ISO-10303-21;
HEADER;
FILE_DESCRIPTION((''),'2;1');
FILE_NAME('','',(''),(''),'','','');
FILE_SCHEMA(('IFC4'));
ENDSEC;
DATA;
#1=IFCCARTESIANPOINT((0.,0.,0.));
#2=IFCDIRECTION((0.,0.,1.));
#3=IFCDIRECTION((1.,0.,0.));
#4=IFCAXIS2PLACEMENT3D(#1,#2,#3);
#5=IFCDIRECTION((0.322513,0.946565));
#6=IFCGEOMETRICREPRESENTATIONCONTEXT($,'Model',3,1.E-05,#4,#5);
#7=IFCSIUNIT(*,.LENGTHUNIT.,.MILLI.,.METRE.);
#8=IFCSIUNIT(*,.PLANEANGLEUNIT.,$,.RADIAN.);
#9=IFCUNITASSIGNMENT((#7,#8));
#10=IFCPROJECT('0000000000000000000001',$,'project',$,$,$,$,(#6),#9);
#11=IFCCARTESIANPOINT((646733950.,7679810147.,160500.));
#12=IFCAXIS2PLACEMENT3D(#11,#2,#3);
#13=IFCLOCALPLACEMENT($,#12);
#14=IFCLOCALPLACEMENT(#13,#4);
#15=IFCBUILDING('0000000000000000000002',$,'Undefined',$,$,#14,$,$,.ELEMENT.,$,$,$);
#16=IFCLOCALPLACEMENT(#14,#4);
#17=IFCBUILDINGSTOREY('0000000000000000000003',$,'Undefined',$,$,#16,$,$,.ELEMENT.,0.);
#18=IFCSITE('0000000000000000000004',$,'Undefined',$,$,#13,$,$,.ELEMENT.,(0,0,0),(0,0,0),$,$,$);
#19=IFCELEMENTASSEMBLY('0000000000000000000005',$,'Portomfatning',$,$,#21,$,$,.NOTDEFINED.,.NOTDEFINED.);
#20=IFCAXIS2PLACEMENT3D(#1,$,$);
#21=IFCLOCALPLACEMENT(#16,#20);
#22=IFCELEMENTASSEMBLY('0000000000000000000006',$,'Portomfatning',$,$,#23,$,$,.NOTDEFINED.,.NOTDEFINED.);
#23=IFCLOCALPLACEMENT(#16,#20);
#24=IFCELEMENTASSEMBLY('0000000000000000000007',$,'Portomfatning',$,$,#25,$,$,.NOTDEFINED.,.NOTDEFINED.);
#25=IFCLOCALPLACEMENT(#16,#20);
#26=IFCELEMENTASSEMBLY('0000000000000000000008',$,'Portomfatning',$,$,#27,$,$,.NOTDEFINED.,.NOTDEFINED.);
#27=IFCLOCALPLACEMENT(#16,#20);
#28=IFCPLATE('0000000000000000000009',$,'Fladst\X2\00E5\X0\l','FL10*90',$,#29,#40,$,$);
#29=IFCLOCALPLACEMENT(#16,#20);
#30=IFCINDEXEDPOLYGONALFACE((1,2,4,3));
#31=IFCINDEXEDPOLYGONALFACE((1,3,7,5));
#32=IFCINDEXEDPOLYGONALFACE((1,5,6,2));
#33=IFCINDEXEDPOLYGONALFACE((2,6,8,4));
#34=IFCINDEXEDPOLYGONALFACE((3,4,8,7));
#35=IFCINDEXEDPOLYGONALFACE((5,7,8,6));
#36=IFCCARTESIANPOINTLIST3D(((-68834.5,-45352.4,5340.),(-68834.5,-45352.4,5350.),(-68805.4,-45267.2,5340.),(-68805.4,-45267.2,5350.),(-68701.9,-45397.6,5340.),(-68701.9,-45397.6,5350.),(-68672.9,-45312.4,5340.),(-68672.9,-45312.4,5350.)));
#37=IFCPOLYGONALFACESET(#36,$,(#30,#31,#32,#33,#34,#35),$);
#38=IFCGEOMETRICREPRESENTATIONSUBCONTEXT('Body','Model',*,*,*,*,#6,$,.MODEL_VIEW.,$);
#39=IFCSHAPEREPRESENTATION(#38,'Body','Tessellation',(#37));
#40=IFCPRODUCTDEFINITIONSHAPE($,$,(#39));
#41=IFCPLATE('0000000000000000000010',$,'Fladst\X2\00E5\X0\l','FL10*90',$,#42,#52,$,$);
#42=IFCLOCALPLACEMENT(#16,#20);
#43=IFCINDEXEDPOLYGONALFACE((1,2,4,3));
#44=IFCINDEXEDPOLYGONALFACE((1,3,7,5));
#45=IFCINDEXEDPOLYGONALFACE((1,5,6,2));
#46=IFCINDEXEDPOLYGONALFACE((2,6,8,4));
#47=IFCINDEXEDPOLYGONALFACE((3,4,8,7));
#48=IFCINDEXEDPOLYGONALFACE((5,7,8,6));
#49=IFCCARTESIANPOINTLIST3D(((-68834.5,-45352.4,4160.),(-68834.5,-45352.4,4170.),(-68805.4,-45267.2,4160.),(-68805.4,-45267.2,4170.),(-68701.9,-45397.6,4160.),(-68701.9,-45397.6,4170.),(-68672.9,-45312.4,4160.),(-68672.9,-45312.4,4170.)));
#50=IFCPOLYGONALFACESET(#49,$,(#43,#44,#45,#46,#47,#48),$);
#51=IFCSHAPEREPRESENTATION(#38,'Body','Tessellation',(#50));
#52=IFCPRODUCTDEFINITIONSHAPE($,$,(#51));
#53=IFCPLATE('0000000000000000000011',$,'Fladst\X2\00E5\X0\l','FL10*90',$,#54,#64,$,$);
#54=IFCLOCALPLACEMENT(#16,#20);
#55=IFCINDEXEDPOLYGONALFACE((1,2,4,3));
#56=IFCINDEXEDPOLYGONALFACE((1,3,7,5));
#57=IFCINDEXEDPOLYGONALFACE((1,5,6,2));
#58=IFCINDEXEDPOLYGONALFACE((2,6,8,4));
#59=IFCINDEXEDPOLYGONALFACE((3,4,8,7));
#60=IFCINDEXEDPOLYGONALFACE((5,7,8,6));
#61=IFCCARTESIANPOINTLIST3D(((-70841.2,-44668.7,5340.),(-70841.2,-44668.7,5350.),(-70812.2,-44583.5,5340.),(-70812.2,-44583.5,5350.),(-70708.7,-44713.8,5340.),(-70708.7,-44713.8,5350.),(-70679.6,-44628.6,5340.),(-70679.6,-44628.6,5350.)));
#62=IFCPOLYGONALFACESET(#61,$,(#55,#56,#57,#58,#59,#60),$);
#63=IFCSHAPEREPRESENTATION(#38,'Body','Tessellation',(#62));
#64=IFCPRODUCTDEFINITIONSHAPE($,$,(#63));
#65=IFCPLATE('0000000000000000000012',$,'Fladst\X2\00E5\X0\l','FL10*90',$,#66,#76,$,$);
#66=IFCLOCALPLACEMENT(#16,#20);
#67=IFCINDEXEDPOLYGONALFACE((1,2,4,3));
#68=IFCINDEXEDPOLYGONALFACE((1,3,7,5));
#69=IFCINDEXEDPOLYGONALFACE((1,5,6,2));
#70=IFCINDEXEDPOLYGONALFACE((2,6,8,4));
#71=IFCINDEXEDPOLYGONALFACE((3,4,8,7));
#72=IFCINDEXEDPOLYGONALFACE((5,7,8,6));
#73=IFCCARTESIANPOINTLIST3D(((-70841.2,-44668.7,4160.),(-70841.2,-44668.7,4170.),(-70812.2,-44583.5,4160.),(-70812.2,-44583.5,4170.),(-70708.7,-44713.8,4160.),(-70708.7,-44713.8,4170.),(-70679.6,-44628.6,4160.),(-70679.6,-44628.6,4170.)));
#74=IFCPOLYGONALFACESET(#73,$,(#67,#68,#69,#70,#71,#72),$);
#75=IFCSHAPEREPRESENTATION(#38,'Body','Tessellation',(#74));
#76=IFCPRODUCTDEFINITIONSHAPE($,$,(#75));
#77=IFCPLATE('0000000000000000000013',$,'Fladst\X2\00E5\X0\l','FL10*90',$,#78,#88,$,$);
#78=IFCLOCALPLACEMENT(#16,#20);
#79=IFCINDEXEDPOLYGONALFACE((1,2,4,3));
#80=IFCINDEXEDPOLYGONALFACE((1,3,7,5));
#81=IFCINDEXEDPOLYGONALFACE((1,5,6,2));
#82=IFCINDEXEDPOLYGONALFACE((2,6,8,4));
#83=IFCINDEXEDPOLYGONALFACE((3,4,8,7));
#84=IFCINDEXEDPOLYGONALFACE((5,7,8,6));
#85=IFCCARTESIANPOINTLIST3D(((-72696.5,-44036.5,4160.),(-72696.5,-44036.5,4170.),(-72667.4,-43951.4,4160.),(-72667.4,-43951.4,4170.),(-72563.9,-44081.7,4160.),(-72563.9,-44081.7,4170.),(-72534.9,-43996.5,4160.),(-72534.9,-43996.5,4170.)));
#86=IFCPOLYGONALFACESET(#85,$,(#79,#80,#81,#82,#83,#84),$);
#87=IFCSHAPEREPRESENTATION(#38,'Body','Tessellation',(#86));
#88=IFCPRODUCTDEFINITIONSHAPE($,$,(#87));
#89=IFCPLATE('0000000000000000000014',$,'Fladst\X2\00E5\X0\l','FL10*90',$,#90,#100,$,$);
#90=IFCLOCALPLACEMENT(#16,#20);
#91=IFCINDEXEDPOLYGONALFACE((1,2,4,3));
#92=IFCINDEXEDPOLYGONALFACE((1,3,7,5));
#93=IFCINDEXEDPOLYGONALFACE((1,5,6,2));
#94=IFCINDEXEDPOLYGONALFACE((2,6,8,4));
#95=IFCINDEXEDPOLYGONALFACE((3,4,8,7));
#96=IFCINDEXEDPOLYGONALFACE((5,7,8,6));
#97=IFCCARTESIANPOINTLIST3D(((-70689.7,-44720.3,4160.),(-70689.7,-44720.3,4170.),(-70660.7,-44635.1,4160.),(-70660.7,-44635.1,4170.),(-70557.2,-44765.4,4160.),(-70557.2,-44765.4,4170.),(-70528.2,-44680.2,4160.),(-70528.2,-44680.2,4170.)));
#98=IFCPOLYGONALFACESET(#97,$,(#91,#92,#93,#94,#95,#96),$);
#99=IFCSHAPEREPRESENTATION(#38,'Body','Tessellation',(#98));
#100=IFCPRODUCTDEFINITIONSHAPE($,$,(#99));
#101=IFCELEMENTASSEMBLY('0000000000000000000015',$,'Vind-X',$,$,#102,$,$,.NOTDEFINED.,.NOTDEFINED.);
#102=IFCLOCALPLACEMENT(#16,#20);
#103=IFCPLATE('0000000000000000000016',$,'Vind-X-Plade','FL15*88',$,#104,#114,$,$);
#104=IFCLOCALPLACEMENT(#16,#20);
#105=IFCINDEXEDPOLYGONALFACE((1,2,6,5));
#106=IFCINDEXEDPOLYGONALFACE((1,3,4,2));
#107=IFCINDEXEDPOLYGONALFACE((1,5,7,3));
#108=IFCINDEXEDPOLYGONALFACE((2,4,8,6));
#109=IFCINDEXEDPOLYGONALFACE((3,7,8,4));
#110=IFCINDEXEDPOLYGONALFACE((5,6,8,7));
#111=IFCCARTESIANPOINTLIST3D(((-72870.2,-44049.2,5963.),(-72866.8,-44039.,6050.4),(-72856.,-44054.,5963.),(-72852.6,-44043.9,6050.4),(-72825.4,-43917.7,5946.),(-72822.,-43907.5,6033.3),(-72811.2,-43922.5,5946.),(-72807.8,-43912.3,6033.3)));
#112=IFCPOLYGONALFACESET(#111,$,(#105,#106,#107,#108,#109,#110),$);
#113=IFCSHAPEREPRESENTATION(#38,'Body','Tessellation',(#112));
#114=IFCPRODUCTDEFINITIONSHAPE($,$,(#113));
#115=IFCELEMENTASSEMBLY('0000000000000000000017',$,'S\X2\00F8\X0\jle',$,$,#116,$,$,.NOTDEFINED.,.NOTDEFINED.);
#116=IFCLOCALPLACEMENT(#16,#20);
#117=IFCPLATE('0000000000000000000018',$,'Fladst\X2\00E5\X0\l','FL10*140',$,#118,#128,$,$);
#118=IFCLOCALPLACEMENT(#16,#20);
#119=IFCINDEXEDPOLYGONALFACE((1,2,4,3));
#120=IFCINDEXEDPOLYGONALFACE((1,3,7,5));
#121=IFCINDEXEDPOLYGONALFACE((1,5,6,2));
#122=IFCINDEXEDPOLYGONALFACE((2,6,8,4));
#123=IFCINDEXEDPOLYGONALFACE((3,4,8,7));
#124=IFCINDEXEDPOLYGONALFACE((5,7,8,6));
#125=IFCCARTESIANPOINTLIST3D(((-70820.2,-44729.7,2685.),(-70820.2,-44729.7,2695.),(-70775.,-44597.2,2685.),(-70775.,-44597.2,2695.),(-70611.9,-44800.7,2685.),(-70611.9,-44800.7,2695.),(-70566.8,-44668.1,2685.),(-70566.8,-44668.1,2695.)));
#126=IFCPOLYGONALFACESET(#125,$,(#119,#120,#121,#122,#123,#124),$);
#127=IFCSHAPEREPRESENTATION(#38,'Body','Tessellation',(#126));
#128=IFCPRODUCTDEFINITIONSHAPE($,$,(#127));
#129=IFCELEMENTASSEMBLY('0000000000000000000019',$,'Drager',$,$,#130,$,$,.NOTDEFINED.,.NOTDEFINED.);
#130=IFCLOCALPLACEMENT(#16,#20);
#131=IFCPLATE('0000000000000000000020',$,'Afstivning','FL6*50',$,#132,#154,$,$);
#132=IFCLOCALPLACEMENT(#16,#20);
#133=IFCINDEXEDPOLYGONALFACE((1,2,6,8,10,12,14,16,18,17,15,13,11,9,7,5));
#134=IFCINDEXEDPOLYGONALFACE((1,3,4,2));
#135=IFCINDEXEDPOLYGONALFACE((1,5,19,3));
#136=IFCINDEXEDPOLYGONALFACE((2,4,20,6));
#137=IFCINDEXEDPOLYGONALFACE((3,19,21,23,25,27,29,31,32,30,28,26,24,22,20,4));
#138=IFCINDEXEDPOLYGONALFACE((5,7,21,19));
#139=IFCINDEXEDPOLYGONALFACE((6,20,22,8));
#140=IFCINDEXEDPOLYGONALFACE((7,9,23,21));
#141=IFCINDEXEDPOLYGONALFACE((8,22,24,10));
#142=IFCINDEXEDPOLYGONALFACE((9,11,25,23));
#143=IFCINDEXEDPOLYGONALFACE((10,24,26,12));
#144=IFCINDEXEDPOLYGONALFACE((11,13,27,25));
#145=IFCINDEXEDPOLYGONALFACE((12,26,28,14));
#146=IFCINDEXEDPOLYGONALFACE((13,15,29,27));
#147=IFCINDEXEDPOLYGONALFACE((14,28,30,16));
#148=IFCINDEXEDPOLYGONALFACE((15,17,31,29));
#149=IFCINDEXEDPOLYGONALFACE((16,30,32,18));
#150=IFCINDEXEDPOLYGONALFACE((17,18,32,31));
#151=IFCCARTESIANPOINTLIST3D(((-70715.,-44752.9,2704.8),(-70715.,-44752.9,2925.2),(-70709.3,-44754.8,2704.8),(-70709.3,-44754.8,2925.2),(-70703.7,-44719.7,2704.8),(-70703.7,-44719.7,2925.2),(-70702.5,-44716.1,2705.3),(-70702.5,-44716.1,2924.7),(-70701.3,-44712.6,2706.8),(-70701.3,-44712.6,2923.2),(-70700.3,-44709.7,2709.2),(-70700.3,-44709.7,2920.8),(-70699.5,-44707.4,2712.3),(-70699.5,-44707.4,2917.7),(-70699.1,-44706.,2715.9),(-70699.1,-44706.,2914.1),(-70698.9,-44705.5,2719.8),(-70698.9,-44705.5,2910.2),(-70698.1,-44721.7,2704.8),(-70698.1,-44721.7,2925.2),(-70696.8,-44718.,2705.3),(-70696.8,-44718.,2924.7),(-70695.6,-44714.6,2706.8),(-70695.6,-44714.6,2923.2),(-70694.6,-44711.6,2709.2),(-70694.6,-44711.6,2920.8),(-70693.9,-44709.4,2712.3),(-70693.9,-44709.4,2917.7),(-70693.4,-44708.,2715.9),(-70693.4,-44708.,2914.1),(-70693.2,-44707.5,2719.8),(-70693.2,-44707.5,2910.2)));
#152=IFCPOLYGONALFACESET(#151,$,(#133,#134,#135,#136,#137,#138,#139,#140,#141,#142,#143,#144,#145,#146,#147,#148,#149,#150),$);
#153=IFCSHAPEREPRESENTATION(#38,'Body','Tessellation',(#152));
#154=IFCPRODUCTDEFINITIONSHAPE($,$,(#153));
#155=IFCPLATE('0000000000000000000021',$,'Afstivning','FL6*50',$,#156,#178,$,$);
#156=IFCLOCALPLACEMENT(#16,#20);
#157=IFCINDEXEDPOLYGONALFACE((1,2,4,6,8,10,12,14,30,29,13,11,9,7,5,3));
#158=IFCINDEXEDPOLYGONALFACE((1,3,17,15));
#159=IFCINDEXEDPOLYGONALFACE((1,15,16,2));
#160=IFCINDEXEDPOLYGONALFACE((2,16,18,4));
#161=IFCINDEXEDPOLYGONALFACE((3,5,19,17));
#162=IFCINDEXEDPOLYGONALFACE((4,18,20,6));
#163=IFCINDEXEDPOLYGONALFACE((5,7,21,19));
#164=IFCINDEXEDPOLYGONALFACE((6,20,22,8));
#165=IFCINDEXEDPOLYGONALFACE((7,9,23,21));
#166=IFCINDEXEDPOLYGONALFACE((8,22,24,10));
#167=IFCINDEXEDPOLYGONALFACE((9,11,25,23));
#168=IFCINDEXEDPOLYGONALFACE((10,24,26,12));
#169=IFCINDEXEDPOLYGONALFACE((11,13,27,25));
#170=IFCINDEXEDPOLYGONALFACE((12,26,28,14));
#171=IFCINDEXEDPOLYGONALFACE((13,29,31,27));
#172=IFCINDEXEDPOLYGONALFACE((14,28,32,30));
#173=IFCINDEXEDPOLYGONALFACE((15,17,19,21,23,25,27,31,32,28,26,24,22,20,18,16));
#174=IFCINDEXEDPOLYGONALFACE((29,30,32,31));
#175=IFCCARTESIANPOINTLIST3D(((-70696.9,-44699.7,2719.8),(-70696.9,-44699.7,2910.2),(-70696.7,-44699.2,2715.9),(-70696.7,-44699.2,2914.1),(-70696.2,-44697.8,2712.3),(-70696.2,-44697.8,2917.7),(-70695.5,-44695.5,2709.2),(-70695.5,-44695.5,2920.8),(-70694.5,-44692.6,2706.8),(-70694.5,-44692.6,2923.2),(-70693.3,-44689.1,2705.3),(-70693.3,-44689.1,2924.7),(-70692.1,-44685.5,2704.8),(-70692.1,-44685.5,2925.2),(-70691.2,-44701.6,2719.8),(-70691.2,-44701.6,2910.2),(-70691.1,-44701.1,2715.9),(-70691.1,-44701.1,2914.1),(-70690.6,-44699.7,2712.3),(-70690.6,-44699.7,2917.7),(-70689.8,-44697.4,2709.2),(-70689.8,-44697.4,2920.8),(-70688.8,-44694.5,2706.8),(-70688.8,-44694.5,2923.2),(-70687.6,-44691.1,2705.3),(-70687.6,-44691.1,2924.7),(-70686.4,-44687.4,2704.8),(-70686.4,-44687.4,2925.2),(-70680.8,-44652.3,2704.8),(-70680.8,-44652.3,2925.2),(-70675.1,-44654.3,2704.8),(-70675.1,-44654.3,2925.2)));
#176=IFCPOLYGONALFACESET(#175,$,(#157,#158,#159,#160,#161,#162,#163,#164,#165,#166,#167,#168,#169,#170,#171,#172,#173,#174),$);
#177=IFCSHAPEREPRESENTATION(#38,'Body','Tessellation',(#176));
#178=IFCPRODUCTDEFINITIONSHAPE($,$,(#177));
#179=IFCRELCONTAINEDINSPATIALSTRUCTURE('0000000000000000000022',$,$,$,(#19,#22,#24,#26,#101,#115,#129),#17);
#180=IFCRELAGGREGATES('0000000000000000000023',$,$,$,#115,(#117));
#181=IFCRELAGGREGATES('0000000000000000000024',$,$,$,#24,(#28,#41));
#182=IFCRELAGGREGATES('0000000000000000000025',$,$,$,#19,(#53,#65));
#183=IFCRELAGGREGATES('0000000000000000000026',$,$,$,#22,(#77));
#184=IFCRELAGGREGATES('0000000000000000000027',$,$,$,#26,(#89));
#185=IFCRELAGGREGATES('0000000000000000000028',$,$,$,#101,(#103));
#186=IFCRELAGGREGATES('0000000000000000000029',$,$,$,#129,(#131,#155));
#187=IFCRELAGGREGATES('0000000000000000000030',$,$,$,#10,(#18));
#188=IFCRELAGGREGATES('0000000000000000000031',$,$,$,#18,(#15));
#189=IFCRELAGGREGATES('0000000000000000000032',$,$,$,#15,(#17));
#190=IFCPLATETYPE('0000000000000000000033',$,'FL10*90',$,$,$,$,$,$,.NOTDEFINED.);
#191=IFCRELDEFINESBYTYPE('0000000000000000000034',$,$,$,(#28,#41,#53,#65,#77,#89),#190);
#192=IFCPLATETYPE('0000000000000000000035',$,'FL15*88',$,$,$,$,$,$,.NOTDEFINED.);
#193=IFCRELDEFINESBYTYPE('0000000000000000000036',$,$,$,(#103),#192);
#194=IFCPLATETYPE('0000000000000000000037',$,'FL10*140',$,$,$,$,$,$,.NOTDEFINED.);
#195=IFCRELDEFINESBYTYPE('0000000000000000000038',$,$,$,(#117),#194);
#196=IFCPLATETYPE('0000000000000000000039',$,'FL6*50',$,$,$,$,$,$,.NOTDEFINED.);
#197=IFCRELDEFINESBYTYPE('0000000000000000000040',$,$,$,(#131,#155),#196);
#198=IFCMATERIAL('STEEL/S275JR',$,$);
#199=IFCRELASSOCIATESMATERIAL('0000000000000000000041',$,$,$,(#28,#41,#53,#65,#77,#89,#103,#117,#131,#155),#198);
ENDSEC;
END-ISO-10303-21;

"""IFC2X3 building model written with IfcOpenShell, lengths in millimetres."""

from ifc_helpers import new_model, si_unit, direction, frame, frame_2d, origin_with_axes, place, context, subcontext, project, spatial, polyline, circle_curve, parameter, trimmed, segment, composite_curve, outline, extrude, material, type_object, element, aggregate, save


model = new_model("IFC2X3")

# Units and contexts
model_context = context("Model", 3, precision=1e-05, world=origin_with_axes(), true_north=direction((0.322513, 0.946565)))
body_context = subcontext(model_context, "Body", "Model", "MODEL_VIEW")
ifc_project = project(units=[si_unit("LENGTHUNIT", "METRE", prefix="MILLI"), si_unit("PLANEANGLEUNIT", "RADIAN")], contexts=[model_context])

# Site, building, storey
site_placement = place(None, frame((646733950.0, 7679810147.0, 160500.0), z_axis=(0.0, 0.0, 1.0), x_axis=(1.0, 0.0, 0.0)))
site = spatial("IfcSite", under=ifc_project, at=site_placement, Name="Undefined", CompositionType="ELEMENT", RefLatitude=(0, 0, 0), RefLongitude=(0, 0, 0))
building_placement = place(site_placement, origin_with_axes())
building = spatial("IfcBuilding", under=site, at=building_placement, Name="Undefined", CompositionType="ELEMENT")
storey_placement = place(building_placement, origin_with_axes())
storey = spatial("IfcBuildingStorey", under=building, at=storey_placement, Name="Undefined", CompositionType="ELEMENT", Elevation=0.0)

# Element assemblies
assembly_1_placement = place(storey_placement, origin_with_axes())
assembly_1 = element("IfcElementAssembly", 1, at=assembly_1_placement, inside=storey, Name="Portomfatning", AssemblyPlace="NOTDEFINED", PredefinedType="NOTDEFINED")
assembly_2_placement = place(storey_placement, origin_with_axes())
assembly_2 = element("IfcElementAssembly", 2, at=assembly_2_placement, inside=storey, Name="Portomfatning", AssemblyPlace="NOTDEFINED", PredefinedType="NOTDEFINED")
assembly_3_placement = place(storey_placement, origin_with_axes())
assembly_3 = element("IfcElementAssembly", 3, at=assembly_3_placement, inside=storey, Name="Portomfatning", AssemblyPlace="NOTDEFINED", PredefinedType="NOTDEFINED")
assembly_4_placement = place(storey_placement, origin_with_axes())
assembly_4 = element("IfcElementAssembly", 4, at=assembly_4_placement, inside=storey, Name="Portomfatning", AssemblyPlace="NOTDEFINED", PredefinedType="NOTDEFINED")

# Shared definitions
ifc_material_1 = material(Name="STEEL/S275JR")

# Plates
plate_type_1 = type_object("IfcPlateType", Name="FL10*90", PredefinedType="NOTDEFINED")
plate_1_placement = place(assembly_3_placement, frame((-68820.0, -45309.8, 5345.0), z_axis=(0.0, 0.0, -1.0), x_axis=(0.946565, -0.322513, 0.0)))
plate_1 = element("IfcPlate", 5, at=plate_1_placement, type_object=plate_type_1, material=ifc_material_1, Name="Fladstål", Description="FL10*90", context=body_context, shape_type="SweptSolid", body=[
    extrude(outline(polyline([(0.0, -45.0), (0.0, 45.0), (140.0, 45.0), (140.0, -45.0), (0.0, -45.0)])), frame((0.0, 0.0, -5.0), z_axis=(0.0, 0.0, 1.0), x_axis=(1.0, 0.0, 0.0)), (0.0, 0.0, 1.0), 10.0),
])
plate_2_placement = place(assembly_3_placement, frame((-68820.0, -45309.8, 4165.0), z_axis=(0.0, 0.0, 1.0), x_axis=(0.946565, -0.322513, 0.0)))
plate_2 = element("IfcPlate", 6, at=plate_2_placement, type_object=plate_type_1, material=ifc_material_1, Name="Fladstål", Description="FL10*90", context=body_context, shape_type="SweptSolid", body=[
    extrude(outline(polyline([(0.0, -45.0), (0.0, 45.0), (140.0, 45.0), (140.0, -45.0), (0.0, -45.0)])), frame((0.0, 0.0, -5.0), z_axis=(0.0, 0.0, 1.0), x_axis=(1.0, 0.0, 0.0)), (0.0, 0.0, 1.0), 10.0),
])
plate_3_placement = place(assembly_1_placement, frame((-70826.7, -44626.1, 5345.0), z_axis=(0.0, 0.0, -1.0), x_axis=(0.946565, -0.322513, 0.0)))
plate_3 = element("IfcPlate", 7, at=plate_3_placement, type_object=plate_type_1, material=ifc_material_1, Name="Fladstål", Description="FL10*90", context=body_context, shape_type="SweptSolid", body=[
    extrude(outline(polyline([(0.0, -45.0), (0.0, 45.0), (140.0, 45.0), (140.0, -45.0), (0.0, -45.0)])), frame((0.0, 0.0, -5.0), z_axis=(0.0, 0.0, 1.0), x_axis=(1.0, 0.0, 0.0)), (0.0, 0.0, 1.0), 10.0),
])
plate_4_placement = place(assembly_1_placement, frame((-70826.7, -44626.1, 4165.0), z_axis=(0.0, 0.0, 1.0), x_axis=(0.946565, -0.322513, 0.0)))
plate_4 = element("IfcPlate", 8, at=plate_4_placement, type_object=plate_type_1, material=ifc_material_1, Name="Fladstål", Description="FL10*90", context=body_context, shape_type="SweptSolid", body=[
    extrude(outline(polyline([(0.0, -45.0), (0.0, 45.0), (140.0, 45.0), (140.0, -45.0), (0.0, -45.0)])), frame((0.0, 0.0, -5.0), z_axis=(0.0, 0.0, 1.0), x_axis=(1.0, 0.0, 0.0)), (0.0, 0.0, 1.0), 10.0),
])
plate_5_placement = place(assembly_2_placement, frame((-72549.4, -44039.1, 4165.0), z_axis=(0.0, 0.0, 1.0), x_axis=(-0.946565, 0.322513, 0.0)))
plate_5 = element("IfcPlate", 9, at=plate_5_placement, type_object=plate_type_1, material=ifc_material_1, Name="Fladstål", Description="FL10*90", context=body_context, shape_type="SweptSolid", body=[
    extrude(outline(polyline([(0.0, -45.0), (0.0, 45.0), (140.0, 45.0), (140.0, -45.0), (0.0, -45.0)])), frame((0.0, 0.0, -5.0), z_axis=(0.0, 0.0, 1.0), x_axis=(1.0, 0.0, 0.0)), (0.0, 0.0, 1.0), 10.0),
])
plate_6_placement = place(assembly_4_placement, frame((-70542.7, -44722.8, 4165.0), z_axis=(0.0, 0.0, 1.0), x_axis=(-0.946565, 0.322513, 0.0)))
plate_6 = element("IfcPlate", 10, at=plate_6_placement, type_object=plate_type_1, material=ifc_material_1, Name="Fladstål", Description="FL10*90", context=body_context, shape_type="SweptSolid", body=[
    extrude(outline(polyline([(0.0, -45.0), (0.0, 45.0), (140.0, 45.0), (140.0, -45.0), (0.0, -45.0)])), frame((0.0, 0.0, -5.0), z_axis=(0.0, 0.0, 1.0), x_axis=(1.0, 0.0, 0.0)), (0.0, 0.0, 1.0), 10.0),
])

# Element assemblies, plates
assembly_5_placement = place(storey_placement, origin_with_axes())
assembly_5 = element("IfcElementAssembly", 11, at=assembly_5_placement, inside=storey, Name="Vind-X", AssemblyPlace="NOTDEFINED", PredefinedType="NOTDEFINED")
plate_type_2 = type_object("IfcPlateType", Name="FL15*88", PredefinedType="NOTDEFINED")
plate_7_placement = place(assembly_5_placement, frame((-72818.3, -43920.1, 5946.0), z_axis=(-0.946565, 0.322513, 0.0), x_axis=(-0.320109, -0.93951, 0.121869)))
plate_7 = element("IfcPlate", 12, at=plate_7_placement, type_object=plate_type_2, material=ifc_material_1, Name="Vind-X-Plade", Description="FL15*88", context=body_context, shape_type="SweptSolid", body=[
    extrude(outline(polyline([(0.0, 0.0), (140.0, 0.0), (140.0, 88.0), (0.0, 88.0), (0.0, 0.0)])), frame((0.0, 0.0, -7.5), z_axis=(0.0, 0.0, 1.0), x_axis=(1.0, 0.0, 0.0)), (0.0, 0.0, 1.0), 15.0),
])
assembly_6_placement = place(storey_placement, origin_with_axes())
assembly_6 = element("IfcElementAssembly", 13, at=assembly_6_placement, inside=storey, Name="Søjle", AssemblyPlace="NOTDEFINED", PredefinedType="NOTDEFINED")
plate_type_3 = type_object("IfcPlateType", Name="FL10*140", PredefinedType="NOTDEFINED")
plate_8_placement = place(assembly_6_placement, frame((-70670.9, -44632.7, 2690.0), z_axis=(0.0, 0.0, -1.0), x_axis=(-0.322513, -0.946565, 0.0)))
plate_8 = element("IfcPlate", 14, at=plate_8_placement, type_object=plate_type_3, material=ifc_material_1, Name="Fladstål", Description="FL10*140", context=body_context, shape_type="SweptSolid", body=[
    extrude(outline(polyline([(0.0, -110.0), (0.0, 110.0), (140.0, 110.0), (140.0, -110.0), (0.0, -110.0)])), frame((0.0, 0.0, -5.0), z_axis=(0.0, 0.0, 1.0), x_axis=(1.0, 0.0, 0.0)), (0.0, 0.0, 1.0), 10.0),
])
aggregate(assembly_6, [plate_8])

# Element assembly, plates
assembly_7_placement = place(storey_placement, origin_with_axes())
assembly_7 = element("IfcElementAssembly", 15, at=assembly_7_placement, inside=storey, Name="Drager", AssemblyPlace="NOTDEFINED", PredefinedType="NOTDEFINED")
plate_type_4 = type_object("IfcPlateType", Name="FL6*50", PredefinedType="NOTDEFINED")
plate_9_placement = place(assembly_7_placement, frame((-70696.1, -44706.5, 2704.8), z_axis=(-0.946565, 0.322513, 0.0), x_axis=(-0.322513, -0.946565, 0.0)))
plate_9 = element("IfcPlate", 16, at=plate_9_placement, type_object=plate_type_4, material=ifc_material_1, Name="Afstivning", Description="FL6*50", context=body_context, shape_type="SweptSolid", body=[
    extrude(outline(composite_curve([segment(trimmed(circle_curve(frame_2d((15.0, 15.0), x_axis=(-1.0, 0.0)), 15.0), [parameter(0.0)], [parameter(1.570796)], True, "PARAMETER"), True, "CONTINUOUS"), segment(polyline([(15.0, 0.0), (50.0, 0.0), (50.0, 220.4), (15.0, 220.4)]), True, "CONTINUOUS"), segment(trimmed(circle_curve(frame_2d((15.0, 205.4), x_axis=(0.0, 1.0)), 15.0), [parameter(0.0)], [parameter(1.570796)], True, "PARAMETER"), True, "CONTINUOUS"), segment(polyline([(0.0, 205.4), (0.0, 15.0)]), True, "CONTINUOUS")], self_intersect=True)), frame((0.0, 0.0, -3.0), z_axis=(0.0, 0.0, 1.0), x_axis=(1.0, 0.0, 0.0)), (0.0, 0.0, 1.0), 6.0),
])
plate_10_placement = place(assembly_7_placement, frame((-70677.9, -44653.3, 2704.8), z_axis=(-0.946565, 0.322513, 0.0), x_axis=(-0.322513, -0.946565, 0.0)))
plate_10 = element("IfcPlate", 17, at=plate_10_placement, type_object=plate_type_4, material=ifc_material_1, Name="Afstivning", Description="FL6*50", context=body_context, shape_type="SweptSolid", body=[
    extrude(outline(composite_curve([segment(polyline([(0.0, 0.0), (35.0, 0.0)]), True, "CONTINUOUS"), segment(trimmed(circle_curve(frame_2d((35.0, 15.0), x_axis=(0.0, -1.0)), 15.0), [parameter(0.0)], [parameter(1.570796)], True, "PARAMETER"), True, "CONTINUOUS"), segment(polyline([(50.0, 15.0), (50.0, 205.4)]), True, "CONTINUOUS"), segment(trimmed(circle_curve(frame_2d((35.0, 205.4), x_axis=(1.0, 0.0)), 15.0), [parameter(0.0)], [parameter(1.570796)], True, "PARAMETER"), True, "CONTINUOUS"), segment(polyline([(35.0, 220.4), (0.0, 220.4), (0.0, 0.0)]), True, "CONTINUOUS")], self_intersect=True)), frame((0.0, 0.0, -3.0), z_axis=(0.0, 0.0, 1.0), x_axis=(1.0, 0.0, 0.0)), (0.0, 0.0, 1.0), 6.0),
])

aggregate(assembly_3, [plate_1, plate_2])
aggregate(assembly_1, [plate_3, plate_4])
aggregate(assembly_2, [plate_5])
aggregate(assembly_4, [plate_6])
aggregate(assembly_5, [plate_7])
aggregate(assembly_7, [plate_9, plate_10])

save(model, "model.ifc")
